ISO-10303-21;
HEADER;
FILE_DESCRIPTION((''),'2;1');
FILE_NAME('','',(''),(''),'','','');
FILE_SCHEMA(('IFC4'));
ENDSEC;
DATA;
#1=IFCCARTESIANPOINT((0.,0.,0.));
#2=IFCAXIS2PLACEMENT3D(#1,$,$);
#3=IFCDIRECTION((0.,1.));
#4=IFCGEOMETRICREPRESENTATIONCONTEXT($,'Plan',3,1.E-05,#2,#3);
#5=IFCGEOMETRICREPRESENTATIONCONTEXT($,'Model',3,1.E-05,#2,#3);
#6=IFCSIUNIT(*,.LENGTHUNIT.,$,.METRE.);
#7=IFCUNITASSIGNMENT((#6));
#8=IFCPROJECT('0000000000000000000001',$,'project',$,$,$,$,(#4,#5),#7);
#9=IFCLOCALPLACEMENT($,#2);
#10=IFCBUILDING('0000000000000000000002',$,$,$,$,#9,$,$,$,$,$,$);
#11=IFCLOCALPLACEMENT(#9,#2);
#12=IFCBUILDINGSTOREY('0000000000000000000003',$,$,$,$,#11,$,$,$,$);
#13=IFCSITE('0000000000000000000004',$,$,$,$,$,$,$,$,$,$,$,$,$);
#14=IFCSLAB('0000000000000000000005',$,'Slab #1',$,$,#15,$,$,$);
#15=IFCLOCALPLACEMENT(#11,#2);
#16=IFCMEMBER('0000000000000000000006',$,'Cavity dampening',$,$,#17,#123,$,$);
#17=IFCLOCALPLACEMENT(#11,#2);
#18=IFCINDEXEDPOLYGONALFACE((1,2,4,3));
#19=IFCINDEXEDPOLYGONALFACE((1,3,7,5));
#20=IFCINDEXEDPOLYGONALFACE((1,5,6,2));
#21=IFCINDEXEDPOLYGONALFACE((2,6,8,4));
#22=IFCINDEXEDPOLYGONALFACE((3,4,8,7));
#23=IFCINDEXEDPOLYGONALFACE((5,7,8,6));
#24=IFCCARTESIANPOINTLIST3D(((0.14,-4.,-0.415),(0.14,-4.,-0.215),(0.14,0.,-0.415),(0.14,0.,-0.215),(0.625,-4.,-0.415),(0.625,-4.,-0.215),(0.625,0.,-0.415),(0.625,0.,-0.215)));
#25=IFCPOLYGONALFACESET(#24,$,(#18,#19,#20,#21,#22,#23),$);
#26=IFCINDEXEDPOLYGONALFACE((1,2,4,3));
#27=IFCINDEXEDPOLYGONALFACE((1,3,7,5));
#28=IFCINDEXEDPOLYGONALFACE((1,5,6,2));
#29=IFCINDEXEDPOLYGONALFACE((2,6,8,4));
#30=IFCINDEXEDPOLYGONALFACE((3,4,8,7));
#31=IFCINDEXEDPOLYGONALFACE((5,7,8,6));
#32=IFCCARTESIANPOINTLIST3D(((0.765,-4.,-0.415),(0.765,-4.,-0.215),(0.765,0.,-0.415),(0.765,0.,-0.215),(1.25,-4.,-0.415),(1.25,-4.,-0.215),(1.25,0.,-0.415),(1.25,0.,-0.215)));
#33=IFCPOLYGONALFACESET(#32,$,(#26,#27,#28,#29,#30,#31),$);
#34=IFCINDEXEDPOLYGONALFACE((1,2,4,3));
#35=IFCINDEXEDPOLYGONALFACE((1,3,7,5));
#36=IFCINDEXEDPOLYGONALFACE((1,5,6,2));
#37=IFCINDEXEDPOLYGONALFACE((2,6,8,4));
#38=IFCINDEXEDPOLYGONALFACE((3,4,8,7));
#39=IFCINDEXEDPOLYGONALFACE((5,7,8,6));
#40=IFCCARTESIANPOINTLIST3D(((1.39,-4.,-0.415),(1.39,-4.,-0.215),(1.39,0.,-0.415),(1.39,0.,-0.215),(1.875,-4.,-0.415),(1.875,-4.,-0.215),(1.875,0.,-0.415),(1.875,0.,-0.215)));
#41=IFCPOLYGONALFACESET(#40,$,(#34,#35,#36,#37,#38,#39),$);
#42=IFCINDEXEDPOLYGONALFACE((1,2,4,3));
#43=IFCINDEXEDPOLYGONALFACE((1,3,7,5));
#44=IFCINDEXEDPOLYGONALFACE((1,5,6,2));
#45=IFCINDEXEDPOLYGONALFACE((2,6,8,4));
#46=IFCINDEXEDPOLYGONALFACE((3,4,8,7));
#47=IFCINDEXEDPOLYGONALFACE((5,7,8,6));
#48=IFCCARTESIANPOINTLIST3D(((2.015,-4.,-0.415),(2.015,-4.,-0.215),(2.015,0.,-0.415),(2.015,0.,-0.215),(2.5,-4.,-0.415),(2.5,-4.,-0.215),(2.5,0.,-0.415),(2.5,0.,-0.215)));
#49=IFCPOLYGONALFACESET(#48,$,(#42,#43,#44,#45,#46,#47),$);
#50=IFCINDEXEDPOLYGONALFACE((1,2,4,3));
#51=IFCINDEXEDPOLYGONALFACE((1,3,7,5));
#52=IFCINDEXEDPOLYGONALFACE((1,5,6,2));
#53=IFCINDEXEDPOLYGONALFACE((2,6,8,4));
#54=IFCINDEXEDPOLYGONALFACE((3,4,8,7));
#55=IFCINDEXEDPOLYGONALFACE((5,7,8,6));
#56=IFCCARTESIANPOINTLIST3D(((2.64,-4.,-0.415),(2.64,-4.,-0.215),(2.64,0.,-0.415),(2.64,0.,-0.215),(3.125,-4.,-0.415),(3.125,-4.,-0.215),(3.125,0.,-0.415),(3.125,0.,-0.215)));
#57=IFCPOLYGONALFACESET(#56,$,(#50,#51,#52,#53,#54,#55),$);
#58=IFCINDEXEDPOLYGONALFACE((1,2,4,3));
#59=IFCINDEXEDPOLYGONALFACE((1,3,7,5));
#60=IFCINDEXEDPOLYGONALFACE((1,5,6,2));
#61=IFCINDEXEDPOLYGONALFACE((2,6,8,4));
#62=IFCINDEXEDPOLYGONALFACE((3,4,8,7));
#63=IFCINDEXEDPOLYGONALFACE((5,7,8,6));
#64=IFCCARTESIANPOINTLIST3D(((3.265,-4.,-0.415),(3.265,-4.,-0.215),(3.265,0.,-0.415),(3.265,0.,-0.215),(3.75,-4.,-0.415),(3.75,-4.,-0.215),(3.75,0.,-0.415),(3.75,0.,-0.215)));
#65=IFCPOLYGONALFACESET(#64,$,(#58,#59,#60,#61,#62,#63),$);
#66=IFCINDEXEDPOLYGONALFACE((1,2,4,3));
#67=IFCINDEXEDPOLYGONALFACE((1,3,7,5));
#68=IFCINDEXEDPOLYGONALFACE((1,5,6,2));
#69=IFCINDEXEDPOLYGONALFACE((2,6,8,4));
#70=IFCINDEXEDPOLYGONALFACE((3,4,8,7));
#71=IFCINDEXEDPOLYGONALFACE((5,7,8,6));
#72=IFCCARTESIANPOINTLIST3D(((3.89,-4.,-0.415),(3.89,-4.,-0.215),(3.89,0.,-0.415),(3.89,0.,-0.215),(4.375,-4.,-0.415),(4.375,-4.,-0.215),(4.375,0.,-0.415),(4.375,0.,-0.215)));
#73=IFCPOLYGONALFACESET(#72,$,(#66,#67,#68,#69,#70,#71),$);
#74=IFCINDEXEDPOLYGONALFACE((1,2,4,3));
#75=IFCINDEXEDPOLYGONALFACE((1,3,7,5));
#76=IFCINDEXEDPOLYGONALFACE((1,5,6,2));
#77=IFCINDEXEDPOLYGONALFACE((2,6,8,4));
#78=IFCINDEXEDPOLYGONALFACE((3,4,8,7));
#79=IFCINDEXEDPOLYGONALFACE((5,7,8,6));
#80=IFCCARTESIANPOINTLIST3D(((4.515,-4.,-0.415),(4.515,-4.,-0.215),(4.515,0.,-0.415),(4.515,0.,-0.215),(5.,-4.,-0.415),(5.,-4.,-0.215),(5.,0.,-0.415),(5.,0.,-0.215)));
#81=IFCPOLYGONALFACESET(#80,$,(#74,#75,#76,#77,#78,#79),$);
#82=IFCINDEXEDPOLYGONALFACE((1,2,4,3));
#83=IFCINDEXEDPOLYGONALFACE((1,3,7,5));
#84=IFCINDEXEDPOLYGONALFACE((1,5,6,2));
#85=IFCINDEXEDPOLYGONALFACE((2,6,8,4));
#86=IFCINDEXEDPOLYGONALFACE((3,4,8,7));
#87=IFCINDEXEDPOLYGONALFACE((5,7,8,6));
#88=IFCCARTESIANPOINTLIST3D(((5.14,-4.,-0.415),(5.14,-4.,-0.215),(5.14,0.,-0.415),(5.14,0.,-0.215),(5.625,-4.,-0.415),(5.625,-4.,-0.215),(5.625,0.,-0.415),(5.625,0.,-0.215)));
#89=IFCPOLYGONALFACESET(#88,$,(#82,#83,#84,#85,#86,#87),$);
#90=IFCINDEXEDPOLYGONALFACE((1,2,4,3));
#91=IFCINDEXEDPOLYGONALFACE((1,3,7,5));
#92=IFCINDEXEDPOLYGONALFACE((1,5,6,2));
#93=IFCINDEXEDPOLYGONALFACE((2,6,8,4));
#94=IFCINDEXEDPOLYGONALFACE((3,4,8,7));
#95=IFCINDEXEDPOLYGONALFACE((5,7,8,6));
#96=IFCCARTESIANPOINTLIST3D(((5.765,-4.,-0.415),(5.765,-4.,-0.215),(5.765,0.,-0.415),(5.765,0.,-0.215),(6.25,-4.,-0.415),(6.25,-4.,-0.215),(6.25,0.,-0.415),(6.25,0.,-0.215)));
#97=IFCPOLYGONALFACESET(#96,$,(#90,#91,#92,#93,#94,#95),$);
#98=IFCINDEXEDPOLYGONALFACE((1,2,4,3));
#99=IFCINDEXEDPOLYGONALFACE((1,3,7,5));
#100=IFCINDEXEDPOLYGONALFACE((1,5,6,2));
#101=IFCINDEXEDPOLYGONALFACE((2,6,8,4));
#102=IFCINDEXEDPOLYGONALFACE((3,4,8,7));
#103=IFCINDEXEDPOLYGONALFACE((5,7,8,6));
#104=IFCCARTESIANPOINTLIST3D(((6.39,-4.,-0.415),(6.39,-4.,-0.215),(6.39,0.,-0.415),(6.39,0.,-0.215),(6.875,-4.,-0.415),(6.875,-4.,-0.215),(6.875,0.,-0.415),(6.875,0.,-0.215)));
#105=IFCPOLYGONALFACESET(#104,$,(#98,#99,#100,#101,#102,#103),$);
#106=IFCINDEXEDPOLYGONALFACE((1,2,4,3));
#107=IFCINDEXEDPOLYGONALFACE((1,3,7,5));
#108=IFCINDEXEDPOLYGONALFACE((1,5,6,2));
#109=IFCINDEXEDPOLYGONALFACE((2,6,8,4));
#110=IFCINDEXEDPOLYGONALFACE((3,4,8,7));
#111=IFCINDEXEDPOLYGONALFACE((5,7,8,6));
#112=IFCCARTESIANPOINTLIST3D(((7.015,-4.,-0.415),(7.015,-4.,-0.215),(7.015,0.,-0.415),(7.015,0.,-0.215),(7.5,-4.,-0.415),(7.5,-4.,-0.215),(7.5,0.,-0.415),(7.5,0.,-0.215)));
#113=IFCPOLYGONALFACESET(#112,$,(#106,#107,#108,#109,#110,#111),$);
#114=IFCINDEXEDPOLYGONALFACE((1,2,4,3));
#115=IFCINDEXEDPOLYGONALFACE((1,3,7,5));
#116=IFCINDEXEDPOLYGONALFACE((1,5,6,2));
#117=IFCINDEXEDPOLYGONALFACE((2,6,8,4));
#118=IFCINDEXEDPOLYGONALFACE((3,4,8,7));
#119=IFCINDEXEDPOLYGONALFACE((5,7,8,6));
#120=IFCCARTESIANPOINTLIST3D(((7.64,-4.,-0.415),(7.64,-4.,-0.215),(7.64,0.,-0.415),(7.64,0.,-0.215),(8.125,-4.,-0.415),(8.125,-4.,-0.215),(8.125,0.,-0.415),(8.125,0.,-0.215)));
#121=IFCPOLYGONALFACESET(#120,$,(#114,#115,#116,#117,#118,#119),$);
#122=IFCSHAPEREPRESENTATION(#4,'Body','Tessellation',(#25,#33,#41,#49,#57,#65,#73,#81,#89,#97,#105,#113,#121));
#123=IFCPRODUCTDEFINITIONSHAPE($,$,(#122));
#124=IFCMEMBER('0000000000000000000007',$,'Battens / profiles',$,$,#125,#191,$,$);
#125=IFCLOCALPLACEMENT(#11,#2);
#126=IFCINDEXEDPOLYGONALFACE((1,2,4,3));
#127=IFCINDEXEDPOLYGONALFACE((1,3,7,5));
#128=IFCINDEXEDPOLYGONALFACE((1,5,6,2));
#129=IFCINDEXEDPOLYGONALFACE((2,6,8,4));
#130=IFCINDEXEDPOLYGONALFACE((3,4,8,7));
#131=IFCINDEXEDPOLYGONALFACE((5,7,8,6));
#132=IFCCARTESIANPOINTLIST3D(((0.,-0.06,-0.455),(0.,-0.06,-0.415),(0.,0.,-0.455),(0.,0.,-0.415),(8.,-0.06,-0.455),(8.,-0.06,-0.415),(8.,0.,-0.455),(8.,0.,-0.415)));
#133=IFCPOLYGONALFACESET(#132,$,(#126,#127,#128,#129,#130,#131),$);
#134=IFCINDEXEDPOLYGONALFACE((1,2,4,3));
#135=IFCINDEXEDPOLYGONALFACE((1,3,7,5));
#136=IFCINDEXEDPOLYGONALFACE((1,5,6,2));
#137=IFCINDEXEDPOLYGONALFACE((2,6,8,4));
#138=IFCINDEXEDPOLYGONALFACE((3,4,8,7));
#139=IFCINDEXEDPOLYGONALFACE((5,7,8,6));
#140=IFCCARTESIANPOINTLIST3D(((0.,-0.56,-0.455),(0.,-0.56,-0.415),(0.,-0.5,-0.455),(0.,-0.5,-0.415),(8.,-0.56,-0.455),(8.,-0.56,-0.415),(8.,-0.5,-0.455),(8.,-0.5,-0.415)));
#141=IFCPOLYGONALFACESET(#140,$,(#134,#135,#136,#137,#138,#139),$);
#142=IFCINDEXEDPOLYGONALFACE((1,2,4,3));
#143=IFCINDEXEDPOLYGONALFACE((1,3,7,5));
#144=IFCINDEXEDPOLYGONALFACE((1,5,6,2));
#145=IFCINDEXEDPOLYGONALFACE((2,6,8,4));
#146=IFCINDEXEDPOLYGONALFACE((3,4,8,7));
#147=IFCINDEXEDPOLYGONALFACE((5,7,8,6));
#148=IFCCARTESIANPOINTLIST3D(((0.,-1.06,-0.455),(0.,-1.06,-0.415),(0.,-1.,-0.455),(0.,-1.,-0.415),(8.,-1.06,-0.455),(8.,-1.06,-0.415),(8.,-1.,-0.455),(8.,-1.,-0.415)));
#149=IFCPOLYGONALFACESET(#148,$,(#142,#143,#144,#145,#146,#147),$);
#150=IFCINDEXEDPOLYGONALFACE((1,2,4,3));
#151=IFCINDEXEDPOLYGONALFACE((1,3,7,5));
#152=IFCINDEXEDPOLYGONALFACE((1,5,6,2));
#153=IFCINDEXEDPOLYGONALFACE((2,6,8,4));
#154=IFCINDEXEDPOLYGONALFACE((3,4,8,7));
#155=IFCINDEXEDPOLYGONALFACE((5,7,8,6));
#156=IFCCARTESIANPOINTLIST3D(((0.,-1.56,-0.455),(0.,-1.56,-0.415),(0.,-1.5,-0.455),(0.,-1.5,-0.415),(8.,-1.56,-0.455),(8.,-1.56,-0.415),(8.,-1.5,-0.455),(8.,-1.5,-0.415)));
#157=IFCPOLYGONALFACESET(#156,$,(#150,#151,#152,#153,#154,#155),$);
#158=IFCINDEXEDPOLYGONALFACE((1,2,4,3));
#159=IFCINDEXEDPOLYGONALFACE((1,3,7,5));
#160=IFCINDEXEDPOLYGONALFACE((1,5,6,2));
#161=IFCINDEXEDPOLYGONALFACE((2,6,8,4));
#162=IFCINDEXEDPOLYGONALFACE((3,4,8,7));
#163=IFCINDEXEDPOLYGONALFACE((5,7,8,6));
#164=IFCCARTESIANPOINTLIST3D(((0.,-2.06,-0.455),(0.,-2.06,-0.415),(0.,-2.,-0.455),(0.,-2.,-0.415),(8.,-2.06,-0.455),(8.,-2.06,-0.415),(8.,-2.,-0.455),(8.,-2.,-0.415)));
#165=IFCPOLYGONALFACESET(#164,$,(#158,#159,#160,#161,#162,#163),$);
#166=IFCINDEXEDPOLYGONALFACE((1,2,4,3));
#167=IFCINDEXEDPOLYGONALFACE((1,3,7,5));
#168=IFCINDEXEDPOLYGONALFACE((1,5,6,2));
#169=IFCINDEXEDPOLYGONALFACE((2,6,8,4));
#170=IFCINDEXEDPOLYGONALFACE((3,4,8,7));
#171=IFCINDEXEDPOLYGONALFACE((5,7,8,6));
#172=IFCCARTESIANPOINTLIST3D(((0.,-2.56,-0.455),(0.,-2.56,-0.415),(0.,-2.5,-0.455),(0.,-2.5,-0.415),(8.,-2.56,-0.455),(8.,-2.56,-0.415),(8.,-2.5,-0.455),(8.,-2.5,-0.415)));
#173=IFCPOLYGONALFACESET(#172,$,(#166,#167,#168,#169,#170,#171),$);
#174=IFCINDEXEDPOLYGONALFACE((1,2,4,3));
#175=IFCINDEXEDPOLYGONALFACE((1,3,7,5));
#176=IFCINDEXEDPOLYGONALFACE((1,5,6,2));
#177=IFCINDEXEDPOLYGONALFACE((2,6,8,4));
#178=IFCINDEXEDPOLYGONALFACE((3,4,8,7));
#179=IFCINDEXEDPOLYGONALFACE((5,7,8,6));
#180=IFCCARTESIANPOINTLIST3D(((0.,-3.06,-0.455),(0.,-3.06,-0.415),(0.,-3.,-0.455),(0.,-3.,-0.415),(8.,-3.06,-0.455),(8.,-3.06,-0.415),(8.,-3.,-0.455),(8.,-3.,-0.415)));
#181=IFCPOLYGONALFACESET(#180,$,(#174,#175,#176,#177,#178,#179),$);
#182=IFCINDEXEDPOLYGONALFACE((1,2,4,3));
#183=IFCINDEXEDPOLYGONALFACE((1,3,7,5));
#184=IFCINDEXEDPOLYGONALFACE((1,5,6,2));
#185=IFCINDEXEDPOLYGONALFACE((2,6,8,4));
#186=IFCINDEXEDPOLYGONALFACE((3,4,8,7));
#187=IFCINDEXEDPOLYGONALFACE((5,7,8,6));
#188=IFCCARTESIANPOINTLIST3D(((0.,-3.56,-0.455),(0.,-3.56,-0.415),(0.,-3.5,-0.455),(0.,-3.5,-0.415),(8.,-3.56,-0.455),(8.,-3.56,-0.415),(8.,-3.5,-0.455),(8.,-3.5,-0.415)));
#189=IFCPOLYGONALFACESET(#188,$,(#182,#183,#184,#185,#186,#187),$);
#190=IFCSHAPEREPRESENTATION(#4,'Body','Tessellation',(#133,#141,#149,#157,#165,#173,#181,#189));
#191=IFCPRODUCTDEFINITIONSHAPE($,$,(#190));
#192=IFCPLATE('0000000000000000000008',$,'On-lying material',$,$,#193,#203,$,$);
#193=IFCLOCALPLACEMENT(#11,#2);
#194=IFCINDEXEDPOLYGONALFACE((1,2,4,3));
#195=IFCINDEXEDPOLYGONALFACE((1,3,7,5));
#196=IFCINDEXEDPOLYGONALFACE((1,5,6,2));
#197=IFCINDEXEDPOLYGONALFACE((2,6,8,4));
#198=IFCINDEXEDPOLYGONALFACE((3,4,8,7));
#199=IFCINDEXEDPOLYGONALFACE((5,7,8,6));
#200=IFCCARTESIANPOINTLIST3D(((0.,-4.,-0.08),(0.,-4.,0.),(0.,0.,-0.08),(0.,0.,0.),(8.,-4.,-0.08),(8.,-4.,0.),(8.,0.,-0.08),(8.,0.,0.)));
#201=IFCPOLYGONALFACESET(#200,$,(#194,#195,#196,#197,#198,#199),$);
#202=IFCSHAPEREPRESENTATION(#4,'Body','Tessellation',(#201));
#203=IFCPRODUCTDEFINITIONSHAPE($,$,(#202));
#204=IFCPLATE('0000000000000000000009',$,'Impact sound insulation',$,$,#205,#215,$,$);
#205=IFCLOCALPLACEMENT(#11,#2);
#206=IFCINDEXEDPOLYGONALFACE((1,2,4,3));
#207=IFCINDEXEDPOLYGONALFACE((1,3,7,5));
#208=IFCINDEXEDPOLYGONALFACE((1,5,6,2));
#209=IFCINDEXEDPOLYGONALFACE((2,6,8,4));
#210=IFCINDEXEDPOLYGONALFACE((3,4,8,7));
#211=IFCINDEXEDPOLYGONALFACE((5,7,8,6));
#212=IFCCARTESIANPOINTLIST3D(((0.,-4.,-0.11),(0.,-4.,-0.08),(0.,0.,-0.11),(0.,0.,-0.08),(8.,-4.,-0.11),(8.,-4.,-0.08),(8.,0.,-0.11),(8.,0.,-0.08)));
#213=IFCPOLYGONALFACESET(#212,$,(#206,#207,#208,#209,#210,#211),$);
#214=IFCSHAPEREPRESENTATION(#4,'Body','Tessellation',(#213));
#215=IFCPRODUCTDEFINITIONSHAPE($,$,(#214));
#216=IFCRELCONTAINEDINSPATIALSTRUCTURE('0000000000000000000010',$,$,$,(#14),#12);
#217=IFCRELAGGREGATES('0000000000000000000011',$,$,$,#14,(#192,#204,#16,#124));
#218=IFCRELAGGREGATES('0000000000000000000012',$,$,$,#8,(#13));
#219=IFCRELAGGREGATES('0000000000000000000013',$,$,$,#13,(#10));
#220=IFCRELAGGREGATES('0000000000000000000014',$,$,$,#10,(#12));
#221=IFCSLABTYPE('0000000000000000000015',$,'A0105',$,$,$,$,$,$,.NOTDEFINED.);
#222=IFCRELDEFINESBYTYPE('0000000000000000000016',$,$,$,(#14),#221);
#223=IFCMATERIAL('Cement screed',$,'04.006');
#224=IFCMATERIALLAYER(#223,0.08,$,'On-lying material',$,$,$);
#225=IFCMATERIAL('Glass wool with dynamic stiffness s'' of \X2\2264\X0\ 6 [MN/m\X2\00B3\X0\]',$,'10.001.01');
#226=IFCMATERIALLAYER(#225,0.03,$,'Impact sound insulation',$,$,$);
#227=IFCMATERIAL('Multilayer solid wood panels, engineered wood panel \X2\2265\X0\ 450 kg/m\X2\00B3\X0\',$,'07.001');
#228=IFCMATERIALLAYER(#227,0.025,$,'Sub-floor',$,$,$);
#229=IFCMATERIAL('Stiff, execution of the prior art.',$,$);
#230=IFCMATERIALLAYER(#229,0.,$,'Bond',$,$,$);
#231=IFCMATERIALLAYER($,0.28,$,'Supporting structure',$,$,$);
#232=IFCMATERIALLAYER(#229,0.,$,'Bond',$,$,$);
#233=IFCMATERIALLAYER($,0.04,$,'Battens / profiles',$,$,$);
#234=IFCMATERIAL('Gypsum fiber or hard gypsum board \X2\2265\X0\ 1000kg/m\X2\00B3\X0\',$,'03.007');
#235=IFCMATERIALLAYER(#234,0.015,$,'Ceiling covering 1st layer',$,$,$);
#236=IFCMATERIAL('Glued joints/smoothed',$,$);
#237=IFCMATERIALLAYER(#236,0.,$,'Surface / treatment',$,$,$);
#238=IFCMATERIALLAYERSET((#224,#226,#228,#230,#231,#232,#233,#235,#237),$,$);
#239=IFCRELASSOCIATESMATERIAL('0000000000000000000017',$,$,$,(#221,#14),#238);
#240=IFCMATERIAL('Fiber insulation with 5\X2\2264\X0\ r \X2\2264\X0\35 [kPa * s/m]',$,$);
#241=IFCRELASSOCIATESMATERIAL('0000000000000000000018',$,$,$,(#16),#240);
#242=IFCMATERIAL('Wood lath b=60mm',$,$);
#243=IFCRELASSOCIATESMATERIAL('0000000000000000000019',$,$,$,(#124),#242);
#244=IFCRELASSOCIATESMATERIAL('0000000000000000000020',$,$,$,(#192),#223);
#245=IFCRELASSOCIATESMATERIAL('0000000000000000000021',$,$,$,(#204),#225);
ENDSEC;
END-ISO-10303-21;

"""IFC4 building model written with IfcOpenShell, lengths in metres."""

from ifc_helpers import new_model, si_unit, direction, frame, frame_2d, origin, origin_with_axes, place, context, project, spatial, rectangle, extrude, material, layer, layer_set, type_object, element, aggregate, save


model = new_model("IFC4")

# Units and contexts
plan_context = context("Plan", 3, precision=1e-05, world=origin(), true_north=direction((0.0, 1.0)))
model_context = context("Model", 3, precision=1e-05, world=origin(), true_north=direction((0.0, 1.0)))
ifc_project = project(units=[si_unit("LENGTHUNIT", "METRE")], contexts=[plan_context, model_context])

# Site, building, storey
site = spatial("IfcSite", under=ifc_project)
building_placement = place(None, origin())
building = spatial("IfcBuilding", under=site, at=building_placement)
storey_placement = place(building_placement, origin())
storey = spatial("IfcBuildingStorey", under=building, at=storey_placement)

# Slab, members, plates
ifc_material_1 = material(Name="Cement screed", Category="04.006")
ifc_layer_1 = layer(ifc_material_1, 0.08, Name="On-lying material")
ifc_material_2 = material(Name="Glass wool with dynamic stiffness s' of ≤ 6 [MN/m³]", Category="10.001.01")
ifc_layer_2 = layer(ifc_material_2, 0.03, Name="Impact sound insulation")
ifc_material_3 = material(Name="Multilayer solid wood panels, engineered wood panel ≥ 450 kg/m³", Category="07.001")
ifc_layer_3 = layer(ifc_material_3, 0.025, Name="Sub-floor")
ifc_material_4 = material(Name="Stiff, execution of the prior art.")
ifc_layer_4 = layer(ifc_material_4, 0.0, Name="Bond")
ifc_layer_5 = layer(None, 0.28, Name="Supporting structure")
ifc_layer_6 = layer(ifc_material_4, 0.0, Name="Bond")
ifc_layer_7 = layer(None, 0.04, Name="Battens / profiles")
ifc_material_5 = material(Name="Gypsum fiber or hard gypsum board ≥ 1000kg/m³", Category="03.007")
ifc_layer_8 = layer(ifc_material_5, 0.015, Name="Ceiling covering 1st layer")
ifc_material_6 = material(Name="Glued joints/smoothed")
ifc_layer_9 = layer(ifc_material_6, 0.0, Name="Surface / treatment")
ifc_layer_set = layer_set([ifc_layer_1, ifc_layer_2, ifc_layer_3, ifc_layer_4, ifc_layer_5, ifc_layer_6, ifc_layer_7, ifc_layer_8, ifc_layer_9])
slab_type = type_object("IfcSlabType", Name="A0105", PredefinedType="NOTDEFINED", material=ifc_layer_set)
slab_placement = place(None, frame((0.0, 0.0, 0.0), z_axis=(0.0, 0.0, -1.0), x_axis=(1.0, 0.0, 0.0)))
slab = element("IfcSlab", 1, at=slab_placement, inside=storey, type_object=slab_type, material=ifc_layer_set, Name="Slab #1")
ifc_material_7 = material(Name="Fiber insulation with 5≤ r ≤35 [kPa * s/m]")
member_1_placement = place(slab_placement, origin())
member_1 = element("IfcMember", 2, at=member_1_placement, material=ifc_material_7, Name="Cavity dampening", context=plan_context, shape_type="SweptSolid", body=[
    extrude(rectangle(XDim=0.485, YDim=0.2, at=frame_2d((0.2425, 0.1), x_axis=(1.0, 0.0))), frame((0.14, 4.0, 0.215), z_axis=(0.0, -1.0, 0.0), x_axis=(1.0, 0.0, 0.0)), (0.0, 0.0, 1.0), 4.0),
    extrude(rectangle(XDim=0.485, YDim=0.2, at=frame_2d((0.2425, 0.1), x_axis=(1.0, 0.0))), frame((0.765, 4.0, 0.215), z_axis=(0.0, -1.0, 0.0), x_axis=(1.0, 0.0, 0.0)), (0.0, 0.0, 1.0), 4.0),
    extrude(rectangle(XDim=0.485, YDim=0.2, at=frame_2d((0.2425, 0.1), x_axis=(1.0, 0.0))), frame((1.39, 4.0, 0.215), z_axis=(0.0, -1.0, 0.0), x_axis=(1.0, 0.0, 0.0)), (0.0, 0.0, 1.0), 4.0),
    extrude(rectangle(XDim=0.485, YDim=0.2, at=frame_2d((0.2425, 0.1), x_axis=(1.0, 0.0))), frame((2.015, 4.0, 0.215), z_axis=(0.0, -1.0, 0.0), x_axis=(1.0, 0.0, 0.0)), (0.0, 0.0, 1.0), 4.0),
    extrude(rectangle(XDim=0.485, YDim=0.2, at=frame_2d((0.2425, 0.1), x_axis=(1.0, 0.0))), frame((2.64, 4.0, 0.215), z_axis=(0.0, -1.0, 0.0), x_axis=(1.0, 0.0, 0.0)), (0.0, 0.0, 1.0), 4.0),
    extrude(rectangle(XDim=0.485, YDim=0.2, at=frame_2d((0.2425, 0.1), x_axis=(1.0, 0.0))), frame((3.265, 4.0, 0.215), z_axis=(0.0, -1.0, 0.0), x_axis=(1.0, 0.0, 0.0)), (0.0, 0.0, 1.0), 4.0),
    extrude(rectangle(XDim=0.485, YDim=0.2, at=frame_2d((0.2425, 0.1), x_axis=(1.0, 0.0))), frame((3.89, 4.0, 0.215), z_axis=(0.0, -1.0, 0.0), x_axis=(1.0, 0.0, 0.0)), (0.0, 0.0, 1.0), 4.0),
    extrude(rectangle(XDim=0.485, YDim=0.2, at=frame_2d((0.2425, 0.1), x_axis=(1.0, 0.0))), frame((4.515, 4.0, 0.215), z_axis=(0.0, -1.0, 0.0), x_axis=(1.0, 0.0, 0.0)), (0.0, 0.0, 1.0), 4.0),
    extrude(rectangle(XDim=0.485, YDim=0.2, at=frame_2d((0.2425, 0.1), x_axis=(1.0, 0.0))), frame((5.14, 4.0, 0.215), z_axis=(0.0, -1.0, 0.0), x_axis=(1.0, 0.0, 0.0)), (0.0, 0.0, 1.0), 4.0),
    extrude(rectangle(XDim=0.485, YDim=0.2, at=frame_2d((0.2425, 0.1), x_axis=(1.0, 0.0))), frame((5.765, 4.0, 0.215), z_axis=(0.0, -1.0, 0.0), x_axis=(1.0, 0.0, 0.0)), (0.0, 0.0, 1.0), 4.0),
    extrude(rectangle(XDim=0.485, YDim=0.2, at=frame_2d((0.2425, 0.1), x_axis=(1.0, 0.0))), frame((6.39, 4.0, 0.215), z_axis=(0.0, -1.0, 0.0), x_axis=(1.0, 0.0, 0.0)), (0.0, 0.0, 1.0), 4.0),
    extrude(rectangle(XDim=0.485, YDim=0.2, at=frame_2d((0.2425, 0.1), x_axis=(1.0, 0.0))), frame((7.015, 4.0, 0.215), z_axis=(0.0, -1.0, 0.0), x_axis=(1.0, 0.0, 0.0)), (0.0, 0.0, 1.0), 4.0),
    extrude(rectangle(XDim=0.485, YDim=0.2, at=frame_2d((0.2425, 0.1), x_axis=(1.0, 0.0))), frame((7.64, 4.0, 0.215), z_axis=(0.0, -1.0, 0.0), x_axis=(1.0, 0.0, 0.0)), (0.0, 0.0, 1.0), 4.0),
])
ifc_material_8 = material(Name="Wood lath b=60mm")
member_2_placement = place(slab_placement, origin())
member_2 = element("IfcMember", 3, at=member_2_placement, material=ifc_material_8, Name="Battens / profiles", context=plan_context, shape_type="SweptSolid", body=[
    extrude(rectangle(XDim=0.06, YDim=0.04, at=frame_2d((0.03, 0.02), x_axis=(1.0, 0.0))), frame((0.0, 0.0, 0.415), z_axis=(1.0, 0.0, 0.0), x_axis=(0.0, 1.0, 0.0)), (0.0, 0.0, 1.0), 8.0),
    extrude(rectangle(XDim=0.06, YDim=0.04, at=frame_2d((0.03, 0.02), x_axis=(1.0, 0.0))), frame((0.0, 0.5, 0.415), z_axis=(1.0, 0.0, 0.0), x_axis=(0.0, 1.0, 0.0)), (0.0, 0.0, 1.0), 8.0),
    extrude(rectangle(XDim=0.06, YDim=0.04, at=frame_2d((0.03, 0.02), x_axis=(1.0, 0.0))), frame((0.0, 1.0, 0.415), z_axis=(1.0, 0.0, 0.0), x_axis=(0.0, 1.0, 0.0)), (0.0, 0.0, 1.0), 8.0),
    extrude(rectangle(XDim=0.06, YDim=0.04, at=frame_2d((0.03, 0.02), x_axis=(1.0, 0.0))), frame((0.0, 1.5, 0.415), z_axis=(1.0, 0.0, 0.0), x_axis=(0.0, 1.0, 0.0)), (0.0, 0.0, 1.0), 8.0),
    extrude(rectangle(XDim=0.06, YDim=0.04, at=frame_2d((0.03, 0.02), x_axis=(1.0, 0.0))), frame((0.0, 2.0, 0.415), z_axis=(1.0, 0.0, 0.0), x_axis=(0.0, 1.0, 0.0)), (0.0, 0.0, 1.0), 8.0),
    extrude(rectangle(XDim=0.06, YDim=0.04, at=frame_2d((0.03, 0.02), x_axis=(1.0, 0.0))), frame((0.0, 2.5, 0.415), z_axis=(1.0, 0.0, 0.0), x_axis=(0.0, 1.0, 0.0)), (0.0, 0.0, 1.0), 8.0),
    extrude(rectangle(XDim=0.06, YDim=0.04, at=frame_2d((0.03, 0.02), x_axis=(1.0, 0.0))), frame((0.0, 3.0, 0.415), z_axis=(1.0, 0.0, 0.0), x_axis=(0.0, 1.0, 0.0)), (0.0, 0.0, 1.0), 8.0),
    extrude(rectangle(XDim=0.06, YDim=0.04, at=frame_2d((0.03, 0.02), x_axis=(1.0, 0.0))), frame((0.0, 3.5, 0.415), z_axis=(1.0, 0.0, 0.0), x_axis=(0.0, 1.0, 0.0)), (0.0, 0.0, 1.0), 8.0),
])
plate_1_placement = place(slab_placement, origin())
plate_1 = element("IfcPlate", 4, at=plate_1_placement, material=ifc_material_1, Name="On-lying material", context=plan_context, shape_type="SweptSolid", body=[
    extrude(rectangle(XDim=8.0, YDim=4.0, at=frame_2d((4.0, 2.0), x_axis=(1.0, 0.0))), origin_with_axes(), (0.0, 0.0, 1.0), 0.08),
])
plate_2_placement = place(slab_placement, origin())
plate_2 = element("IfcPlate", 5, at=plate_2_placement, material=ifc_material_2, Name="Impact sound insulation", context=plan_context, shape_type="SweptSolid", body=[
    extrude(rectangle(XDim=8.0, YDim=4.0, at=frame_2d((4.0, 2.0), x_axis=(1.0, 0.0))), frame((0.0, 0.0, 0.08), z_axis=(0.0, 0.0, 1.0), x_axis=(1.0, 0.0, 0.0)), (0.0, 0.0, 1.0), 0.03),
])
aggregate(slab, [plate_1, plate_2, member_1, member_2])

save(model, "model.ifc")
